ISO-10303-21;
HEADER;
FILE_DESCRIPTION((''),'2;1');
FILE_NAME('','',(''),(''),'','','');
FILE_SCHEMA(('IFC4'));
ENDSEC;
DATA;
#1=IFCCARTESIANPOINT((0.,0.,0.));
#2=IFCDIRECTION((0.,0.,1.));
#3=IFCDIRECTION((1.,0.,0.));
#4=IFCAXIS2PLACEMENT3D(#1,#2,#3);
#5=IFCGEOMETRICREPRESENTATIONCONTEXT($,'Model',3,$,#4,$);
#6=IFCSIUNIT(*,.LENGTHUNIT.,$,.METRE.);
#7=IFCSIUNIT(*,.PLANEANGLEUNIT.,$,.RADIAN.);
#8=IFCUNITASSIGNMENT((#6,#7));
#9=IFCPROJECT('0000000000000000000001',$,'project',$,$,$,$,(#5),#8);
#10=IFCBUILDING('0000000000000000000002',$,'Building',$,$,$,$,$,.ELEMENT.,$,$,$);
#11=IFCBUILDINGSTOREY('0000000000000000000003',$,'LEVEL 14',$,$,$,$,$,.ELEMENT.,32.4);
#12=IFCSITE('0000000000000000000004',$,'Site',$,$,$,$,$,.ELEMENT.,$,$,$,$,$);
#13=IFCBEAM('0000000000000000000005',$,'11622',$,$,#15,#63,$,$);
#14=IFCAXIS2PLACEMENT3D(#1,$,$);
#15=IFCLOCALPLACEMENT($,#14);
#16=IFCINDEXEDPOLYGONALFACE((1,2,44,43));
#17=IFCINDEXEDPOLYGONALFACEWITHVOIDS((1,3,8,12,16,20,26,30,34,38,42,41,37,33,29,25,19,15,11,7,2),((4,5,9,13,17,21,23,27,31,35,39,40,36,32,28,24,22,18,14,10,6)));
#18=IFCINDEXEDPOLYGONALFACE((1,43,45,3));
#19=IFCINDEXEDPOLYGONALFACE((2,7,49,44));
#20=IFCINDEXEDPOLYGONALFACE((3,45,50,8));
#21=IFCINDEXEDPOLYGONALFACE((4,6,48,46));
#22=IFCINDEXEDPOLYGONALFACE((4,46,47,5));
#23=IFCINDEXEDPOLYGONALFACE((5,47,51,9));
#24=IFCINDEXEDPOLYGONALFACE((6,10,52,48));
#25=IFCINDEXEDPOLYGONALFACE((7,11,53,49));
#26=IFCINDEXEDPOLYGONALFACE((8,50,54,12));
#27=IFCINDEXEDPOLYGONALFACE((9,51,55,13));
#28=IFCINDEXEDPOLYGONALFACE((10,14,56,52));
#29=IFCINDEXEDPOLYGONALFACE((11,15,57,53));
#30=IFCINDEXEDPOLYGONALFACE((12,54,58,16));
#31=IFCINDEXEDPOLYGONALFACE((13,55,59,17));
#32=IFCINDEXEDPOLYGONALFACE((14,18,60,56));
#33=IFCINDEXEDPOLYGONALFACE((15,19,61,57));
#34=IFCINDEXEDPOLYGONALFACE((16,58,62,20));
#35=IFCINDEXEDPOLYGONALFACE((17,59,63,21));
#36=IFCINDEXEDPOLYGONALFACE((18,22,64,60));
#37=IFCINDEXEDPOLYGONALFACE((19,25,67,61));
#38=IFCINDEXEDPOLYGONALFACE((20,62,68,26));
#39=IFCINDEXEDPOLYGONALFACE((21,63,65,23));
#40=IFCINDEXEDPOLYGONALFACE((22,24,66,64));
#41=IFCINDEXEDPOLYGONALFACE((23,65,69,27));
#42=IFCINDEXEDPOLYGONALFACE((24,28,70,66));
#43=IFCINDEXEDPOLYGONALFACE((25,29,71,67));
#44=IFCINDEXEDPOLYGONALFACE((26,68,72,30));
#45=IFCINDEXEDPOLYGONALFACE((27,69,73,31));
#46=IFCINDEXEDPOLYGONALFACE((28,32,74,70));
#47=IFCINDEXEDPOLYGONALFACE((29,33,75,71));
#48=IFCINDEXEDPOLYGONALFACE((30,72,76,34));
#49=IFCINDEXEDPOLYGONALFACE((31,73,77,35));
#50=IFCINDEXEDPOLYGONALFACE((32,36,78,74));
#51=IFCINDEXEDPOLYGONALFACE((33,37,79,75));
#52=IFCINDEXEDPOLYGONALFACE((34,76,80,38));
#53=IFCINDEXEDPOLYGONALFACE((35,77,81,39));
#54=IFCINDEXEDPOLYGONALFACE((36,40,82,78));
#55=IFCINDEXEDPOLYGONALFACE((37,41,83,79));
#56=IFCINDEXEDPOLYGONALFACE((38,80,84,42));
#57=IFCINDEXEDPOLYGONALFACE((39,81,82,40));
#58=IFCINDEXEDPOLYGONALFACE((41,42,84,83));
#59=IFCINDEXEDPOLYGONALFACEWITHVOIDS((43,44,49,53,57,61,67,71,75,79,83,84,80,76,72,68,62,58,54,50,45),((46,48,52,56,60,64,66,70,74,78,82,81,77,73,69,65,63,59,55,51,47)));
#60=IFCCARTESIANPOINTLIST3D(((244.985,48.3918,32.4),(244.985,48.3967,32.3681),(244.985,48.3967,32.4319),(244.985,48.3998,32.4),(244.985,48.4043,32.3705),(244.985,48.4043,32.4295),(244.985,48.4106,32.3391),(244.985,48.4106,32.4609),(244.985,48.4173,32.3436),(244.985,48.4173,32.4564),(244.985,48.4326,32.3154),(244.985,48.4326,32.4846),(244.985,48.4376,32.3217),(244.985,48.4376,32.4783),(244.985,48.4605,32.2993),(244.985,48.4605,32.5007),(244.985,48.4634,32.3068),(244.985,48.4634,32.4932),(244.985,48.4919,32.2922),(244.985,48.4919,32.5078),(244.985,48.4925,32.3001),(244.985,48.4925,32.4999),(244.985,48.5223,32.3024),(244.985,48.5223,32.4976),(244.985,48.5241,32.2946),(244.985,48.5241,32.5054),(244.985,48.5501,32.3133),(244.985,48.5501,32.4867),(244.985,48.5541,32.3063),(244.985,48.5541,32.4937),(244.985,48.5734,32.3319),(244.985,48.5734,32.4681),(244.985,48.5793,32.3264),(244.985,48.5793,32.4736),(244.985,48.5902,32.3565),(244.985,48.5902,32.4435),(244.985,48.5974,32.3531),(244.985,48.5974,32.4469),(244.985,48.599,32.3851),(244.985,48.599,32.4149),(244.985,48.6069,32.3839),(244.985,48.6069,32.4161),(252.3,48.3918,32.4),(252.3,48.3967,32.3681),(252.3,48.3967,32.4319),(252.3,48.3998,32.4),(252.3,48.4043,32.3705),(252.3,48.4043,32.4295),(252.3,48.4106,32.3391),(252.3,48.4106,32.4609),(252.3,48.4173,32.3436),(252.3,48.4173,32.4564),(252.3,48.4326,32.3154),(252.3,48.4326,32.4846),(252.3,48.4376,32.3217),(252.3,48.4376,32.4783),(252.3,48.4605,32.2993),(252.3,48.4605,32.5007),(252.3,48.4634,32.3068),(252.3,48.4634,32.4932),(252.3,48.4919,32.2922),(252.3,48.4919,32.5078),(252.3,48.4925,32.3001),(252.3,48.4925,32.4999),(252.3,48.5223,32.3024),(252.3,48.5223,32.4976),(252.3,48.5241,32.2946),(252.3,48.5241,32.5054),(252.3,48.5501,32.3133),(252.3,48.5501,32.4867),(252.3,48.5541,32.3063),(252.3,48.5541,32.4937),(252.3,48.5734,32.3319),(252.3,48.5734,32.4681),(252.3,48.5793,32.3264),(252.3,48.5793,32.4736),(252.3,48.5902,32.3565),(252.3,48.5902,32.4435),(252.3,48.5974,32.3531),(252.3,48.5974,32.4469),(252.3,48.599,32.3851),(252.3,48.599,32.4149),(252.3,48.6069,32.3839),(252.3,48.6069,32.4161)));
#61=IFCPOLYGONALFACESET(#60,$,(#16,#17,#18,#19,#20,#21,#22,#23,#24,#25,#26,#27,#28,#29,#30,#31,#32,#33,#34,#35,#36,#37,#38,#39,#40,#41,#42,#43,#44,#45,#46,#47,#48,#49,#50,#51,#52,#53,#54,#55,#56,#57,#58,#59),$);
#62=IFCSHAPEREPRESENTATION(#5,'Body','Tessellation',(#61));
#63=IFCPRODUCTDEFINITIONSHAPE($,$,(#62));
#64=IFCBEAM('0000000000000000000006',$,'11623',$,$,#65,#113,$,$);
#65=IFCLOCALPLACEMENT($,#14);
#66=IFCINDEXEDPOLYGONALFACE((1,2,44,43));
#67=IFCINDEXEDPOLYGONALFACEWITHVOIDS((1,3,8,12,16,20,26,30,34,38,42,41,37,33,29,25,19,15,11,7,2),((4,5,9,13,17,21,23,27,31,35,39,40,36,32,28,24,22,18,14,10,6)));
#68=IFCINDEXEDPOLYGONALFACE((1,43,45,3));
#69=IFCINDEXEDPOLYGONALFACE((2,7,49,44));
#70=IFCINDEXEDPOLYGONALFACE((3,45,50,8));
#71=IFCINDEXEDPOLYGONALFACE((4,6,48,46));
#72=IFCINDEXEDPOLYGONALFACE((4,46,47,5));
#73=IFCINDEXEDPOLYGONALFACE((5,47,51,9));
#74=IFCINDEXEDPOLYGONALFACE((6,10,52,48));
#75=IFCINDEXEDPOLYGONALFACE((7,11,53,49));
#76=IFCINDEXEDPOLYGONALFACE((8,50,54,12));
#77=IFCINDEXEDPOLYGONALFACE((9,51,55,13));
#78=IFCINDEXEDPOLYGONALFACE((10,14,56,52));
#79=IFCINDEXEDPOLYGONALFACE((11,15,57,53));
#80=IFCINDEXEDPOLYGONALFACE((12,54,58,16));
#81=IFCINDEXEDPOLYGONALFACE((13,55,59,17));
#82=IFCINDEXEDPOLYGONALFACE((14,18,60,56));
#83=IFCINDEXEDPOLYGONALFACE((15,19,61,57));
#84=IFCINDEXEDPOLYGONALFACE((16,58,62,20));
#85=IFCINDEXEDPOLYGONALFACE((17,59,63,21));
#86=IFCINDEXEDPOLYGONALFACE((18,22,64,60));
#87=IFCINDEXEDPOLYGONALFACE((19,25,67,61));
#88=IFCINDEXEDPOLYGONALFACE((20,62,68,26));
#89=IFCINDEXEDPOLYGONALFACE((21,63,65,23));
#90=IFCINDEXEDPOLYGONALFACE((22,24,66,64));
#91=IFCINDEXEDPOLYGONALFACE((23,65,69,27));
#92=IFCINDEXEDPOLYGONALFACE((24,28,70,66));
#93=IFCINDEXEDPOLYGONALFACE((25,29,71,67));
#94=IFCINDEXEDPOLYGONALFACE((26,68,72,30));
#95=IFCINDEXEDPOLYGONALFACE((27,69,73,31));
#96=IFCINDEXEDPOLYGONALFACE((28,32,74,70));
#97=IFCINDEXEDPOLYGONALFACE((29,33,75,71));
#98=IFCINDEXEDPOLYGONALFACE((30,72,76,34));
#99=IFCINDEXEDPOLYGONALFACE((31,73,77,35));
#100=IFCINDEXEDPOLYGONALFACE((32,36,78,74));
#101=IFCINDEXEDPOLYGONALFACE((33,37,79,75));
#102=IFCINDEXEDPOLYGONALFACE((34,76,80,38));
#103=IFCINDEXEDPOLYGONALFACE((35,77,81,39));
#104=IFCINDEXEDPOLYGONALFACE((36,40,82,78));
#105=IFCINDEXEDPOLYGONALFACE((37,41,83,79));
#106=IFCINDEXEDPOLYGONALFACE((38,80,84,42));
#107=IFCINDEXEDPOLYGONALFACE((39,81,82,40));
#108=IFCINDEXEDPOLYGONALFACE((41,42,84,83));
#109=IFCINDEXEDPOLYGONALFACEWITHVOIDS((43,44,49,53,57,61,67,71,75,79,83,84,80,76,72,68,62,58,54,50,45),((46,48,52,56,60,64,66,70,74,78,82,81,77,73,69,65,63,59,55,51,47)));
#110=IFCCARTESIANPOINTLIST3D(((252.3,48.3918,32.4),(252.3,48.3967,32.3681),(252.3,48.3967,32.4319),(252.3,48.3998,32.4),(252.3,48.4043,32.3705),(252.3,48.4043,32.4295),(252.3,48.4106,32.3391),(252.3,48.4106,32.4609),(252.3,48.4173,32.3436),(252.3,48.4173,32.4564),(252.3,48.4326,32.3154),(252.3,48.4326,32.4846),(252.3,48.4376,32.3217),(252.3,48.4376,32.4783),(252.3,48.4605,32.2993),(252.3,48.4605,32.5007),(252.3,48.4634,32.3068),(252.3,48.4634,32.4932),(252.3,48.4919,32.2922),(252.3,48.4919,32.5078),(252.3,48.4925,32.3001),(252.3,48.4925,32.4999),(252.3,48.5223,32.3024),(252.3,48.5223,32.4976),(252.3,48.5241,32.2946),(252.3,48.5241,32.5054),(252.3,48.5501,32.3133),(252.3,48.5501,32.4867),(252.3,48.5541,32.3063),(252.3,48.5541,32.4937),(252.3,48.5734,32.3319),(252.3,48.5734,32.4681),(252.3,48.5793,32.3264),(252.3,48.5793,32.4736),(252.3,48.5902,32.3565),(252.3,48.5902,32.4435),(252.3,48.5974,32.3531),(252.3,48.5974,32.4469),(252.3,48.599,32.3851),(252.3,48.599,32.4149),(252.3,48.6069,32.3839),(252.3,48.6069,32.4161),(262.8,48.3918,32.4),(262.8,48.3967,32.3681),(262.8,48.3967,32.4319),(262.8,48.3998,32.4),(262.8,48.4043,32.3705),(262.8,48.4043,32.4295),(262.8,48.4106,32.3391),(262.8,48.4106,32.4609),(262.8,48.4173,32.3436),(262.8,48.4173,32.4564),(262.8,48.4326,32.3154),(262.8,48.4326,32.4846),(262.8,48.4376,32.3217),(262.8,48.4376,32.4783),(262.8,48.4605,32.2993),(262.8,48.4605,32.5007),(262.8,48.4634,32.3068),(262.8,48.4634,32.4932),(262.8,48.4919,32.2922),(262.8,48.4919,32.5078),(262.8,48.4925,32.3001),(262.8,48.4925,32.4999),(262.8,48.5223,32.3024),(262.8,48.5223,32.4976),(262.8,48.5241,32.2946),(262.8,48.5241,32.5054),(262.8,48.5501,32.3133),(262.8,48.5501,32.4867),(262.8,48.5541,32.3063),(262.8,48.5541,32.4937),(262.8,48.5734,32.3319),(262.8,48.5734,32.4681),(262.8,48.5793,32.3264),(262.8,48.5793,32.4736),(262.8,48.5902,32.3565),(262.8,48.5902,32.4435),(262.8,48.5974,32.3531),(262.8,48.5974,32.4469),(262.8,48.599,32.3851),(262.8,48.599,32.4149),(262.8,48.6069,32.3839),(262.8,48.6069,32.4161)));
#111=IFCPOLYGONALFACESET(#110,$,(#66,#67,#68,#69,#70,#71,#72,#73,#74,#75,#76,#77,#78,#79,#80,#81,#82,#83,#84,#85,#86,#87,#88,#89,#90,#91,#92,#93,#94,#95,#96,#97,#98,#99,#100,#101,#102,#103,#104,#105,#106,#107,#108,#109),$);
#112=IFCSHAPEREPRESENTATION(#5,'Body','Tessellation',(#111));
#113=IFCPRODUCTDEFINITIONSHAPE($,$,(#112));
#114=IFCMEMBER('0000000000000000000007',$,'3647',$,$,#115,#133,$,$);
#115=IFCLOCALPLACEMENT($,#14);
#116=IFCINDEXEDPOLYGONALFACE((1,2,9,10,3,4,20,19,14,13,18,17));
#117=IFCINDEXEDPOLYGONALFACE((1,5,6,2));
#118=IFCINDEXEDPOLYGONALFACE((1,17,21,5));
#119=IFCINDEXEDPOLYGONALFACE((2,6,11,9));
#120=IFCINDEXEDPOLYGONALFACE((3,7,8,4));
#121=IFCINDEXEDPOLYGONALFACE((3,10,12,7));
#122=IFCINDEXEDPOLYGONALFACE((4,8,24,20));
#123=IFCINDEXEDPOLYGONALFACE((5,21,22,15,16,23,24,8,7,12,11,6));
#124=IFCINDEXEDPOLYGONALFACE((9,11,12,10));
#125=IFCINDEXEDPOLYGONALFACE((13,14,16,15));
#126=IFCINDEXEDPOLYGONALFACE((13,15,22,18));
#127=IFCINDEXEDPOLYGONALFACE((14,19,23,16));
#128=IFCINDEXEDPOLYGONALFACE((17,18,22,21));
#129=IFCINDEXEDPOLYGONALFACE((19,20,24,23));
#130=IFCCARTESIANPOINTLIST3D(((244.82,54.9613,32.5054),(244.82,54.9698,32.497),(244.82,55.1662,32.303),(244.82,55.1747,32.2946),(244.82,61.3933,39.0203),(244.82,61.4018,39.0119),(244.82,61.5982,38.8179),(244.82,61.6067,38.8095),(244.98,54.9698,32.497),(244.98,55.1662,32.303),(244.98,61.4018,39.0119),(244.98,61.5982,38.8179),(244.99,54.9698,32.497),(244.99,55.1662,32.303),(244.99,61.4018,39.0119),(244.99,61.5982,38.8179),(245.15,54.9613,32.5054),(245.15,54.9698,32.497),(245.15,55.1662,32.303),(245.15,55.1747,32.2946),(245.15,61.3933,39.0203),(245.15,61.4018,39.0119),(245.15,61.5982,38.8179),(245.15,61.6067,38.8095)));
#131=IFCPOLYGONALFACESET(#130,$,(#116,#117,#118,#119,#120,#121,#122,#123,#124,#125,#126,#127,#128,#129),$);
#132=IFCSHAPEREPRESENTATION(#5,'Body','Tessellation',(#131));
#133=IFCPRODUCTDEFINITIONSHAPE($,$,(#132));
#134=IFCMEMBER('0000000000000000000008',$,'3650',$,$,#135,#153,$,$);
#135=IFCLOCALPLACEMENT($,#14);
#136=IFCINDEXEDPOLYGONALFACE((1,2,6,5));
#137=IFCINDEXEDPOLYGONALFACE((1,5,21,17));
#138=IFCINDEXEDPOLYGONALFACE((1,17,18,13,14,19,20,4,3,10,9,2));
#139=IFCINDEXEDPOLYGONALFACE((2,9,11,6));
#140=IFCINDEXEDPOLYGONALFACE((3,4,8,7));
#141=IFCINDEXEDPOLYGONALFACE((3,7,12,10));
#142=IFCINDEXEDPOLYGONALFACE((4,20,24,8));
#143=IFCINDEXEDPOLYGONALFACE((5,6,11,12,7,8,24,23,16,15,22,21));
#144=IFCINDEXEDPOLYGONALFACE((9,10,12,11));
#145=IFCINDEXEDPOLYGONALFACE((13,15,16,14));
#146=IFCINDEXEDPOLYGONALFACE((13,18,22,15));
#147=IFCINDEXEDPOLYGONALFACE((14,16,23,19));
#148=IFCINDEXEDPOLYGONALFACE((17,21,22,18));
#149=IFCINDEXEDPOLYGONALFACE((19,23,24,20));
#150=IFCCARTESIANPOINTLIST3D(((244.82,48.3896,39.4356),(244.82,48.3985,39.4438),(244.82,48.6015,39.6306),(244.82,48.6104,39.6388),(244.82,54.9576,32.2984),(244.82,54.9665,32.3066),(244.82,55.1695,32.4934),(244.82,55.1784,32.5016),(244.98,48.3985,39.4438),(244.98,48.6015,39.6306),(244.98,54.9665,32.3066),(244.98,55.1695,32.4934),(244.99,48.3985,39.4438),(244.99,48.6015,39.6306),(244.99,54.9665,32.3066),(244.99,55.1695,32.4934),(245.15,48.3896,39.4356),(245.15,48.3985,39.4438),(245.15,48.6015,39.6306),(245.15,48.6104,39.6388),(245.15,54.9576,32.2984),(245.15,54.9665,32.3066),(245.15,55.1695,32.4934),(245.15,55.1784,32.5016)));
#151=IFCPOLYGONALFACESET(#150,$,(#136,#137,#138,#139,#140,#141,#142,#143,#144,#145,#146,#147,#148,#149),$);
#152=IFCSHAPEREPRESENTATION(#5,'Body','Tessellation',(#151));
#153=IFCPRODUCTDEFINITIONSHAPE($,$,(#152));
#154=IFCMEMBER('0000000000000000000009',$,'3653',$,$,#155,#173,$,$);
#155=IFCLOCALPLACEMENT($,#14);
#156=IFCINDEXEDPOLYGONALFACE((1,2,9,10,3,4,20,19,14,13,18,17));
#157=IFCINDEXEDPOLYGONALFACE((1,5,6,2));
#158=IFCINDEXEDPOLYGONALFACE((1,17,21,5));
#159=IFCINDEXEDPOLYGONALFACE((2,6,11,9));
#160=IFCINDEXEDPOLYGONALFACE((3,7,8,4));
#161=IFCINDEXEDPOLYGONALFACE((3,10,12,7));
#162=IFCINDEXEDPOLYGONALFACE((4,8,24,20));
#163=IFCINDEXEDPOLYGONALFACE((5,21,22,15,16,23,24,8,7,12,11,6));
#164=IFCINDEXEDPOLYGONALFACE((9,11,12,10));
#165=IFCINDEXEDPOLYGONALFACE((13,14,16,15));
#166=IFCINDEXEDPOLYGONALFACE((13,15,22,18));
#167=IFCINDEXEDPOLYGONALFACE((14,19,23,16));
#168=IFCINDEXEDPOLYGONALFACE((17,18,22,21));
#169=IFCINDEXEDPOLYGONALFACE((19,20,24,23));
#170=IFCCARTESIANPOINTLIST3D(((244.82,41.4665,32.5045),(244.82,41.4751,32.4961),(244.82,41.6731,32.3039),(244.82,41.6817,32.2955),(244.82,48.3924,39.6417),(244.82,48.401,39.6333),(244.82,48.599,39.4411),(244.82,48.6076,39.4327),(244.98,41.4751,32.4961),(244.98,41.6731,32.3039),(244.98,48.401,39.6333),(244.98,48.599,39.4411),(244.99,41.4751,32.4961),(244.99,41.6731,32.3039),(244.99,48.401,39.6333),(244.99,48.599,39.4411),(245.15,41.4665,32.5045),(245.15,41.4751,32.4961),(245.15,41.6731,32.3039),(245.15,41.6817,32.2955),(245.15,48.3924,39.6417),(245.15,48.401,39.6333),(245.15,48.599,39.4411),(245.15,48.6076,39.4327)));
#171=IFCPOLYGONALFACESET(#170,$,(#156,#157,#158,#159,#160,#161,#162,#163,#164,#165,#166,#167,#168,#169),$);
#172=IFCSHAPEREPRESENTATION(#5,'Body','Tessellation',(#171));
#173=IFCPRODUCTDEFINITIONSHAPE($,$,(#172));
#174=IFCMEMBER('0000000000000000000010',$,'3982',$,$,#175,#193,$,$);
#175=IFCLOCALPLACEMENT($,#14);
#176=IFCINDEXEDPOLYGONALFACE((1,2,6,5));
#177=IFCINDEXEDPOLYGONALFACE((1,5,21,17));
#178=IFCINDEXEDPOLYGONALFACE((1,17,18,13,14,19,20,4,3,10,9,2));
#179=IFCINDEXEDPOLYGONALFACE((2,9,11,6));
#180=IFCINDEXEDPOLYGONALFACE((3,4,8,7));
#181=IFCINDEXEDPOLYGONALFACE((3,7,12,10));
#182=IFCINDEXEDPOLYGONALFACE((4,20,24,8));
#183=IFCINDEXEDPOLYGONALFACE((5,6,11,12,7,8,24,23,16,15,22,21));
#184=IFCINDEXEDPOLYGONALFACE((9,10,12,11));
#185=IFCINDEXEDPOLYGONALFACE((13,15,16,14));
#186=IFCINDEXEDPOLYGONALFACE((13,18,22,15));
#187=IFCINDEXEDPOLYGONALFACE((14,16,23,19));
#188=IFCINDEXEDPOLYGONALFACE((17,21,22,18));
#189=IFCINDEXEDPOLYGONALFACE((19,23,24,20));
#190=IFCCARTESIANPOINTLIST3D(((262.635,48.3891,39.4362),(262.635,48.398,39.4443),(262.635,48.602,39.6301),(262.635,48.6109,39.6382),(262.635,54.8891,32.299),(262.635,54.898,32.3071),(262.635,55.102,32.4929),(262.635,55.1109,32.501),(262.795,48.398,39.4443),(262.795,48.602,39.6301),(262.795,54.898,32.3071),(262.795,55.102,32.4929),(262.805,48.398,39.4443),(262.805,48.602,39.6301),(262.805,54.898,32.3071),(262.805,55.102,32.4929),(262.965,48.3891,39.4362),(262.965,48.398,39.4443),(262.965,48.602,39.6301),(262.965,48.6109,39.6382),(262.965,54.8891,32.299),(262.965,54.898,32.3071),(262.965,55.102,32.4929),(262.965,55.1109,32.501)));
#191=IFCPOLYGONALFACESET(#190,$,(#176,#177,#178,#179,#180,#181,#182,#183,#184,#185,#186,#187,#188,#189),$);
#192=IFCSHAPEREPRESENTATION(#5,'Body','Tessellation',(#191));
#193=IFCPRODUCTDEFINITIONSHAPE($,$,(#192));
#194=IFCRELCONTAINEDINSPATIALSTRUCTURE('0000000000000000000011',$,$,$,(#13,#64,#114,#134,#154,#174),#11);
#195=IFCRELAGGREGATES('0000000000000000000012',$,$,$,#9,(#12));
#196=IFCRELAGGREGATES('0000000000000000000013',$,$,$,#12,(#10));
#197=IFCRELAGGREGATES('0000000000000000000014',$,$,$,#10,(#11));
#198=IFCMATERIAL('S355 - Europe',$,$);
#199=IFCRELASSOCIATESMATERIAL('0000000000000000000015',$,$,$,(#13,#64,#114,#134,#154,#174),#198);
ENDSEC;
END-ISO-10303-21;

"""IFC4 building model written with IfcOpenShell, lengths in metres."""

from ifc_helpers import new_model, si_unit, frame, origin_with_axes, origin_2d_with_axis, place, context, project, spatial, hollow_circle, i_section, extrude, material, material_profile, profile_set, profile_usage, element, save


model = new_model("IFC4")

# Units and contexts
model_context = context("Model", 3, world=origin_with_axes())
ifc_project = project(units=[si_unit("LENGTHUNIT", "METRE"), si_unit("PLANEANGLEUNIT", "RADIAN")], contexts=[model_context])

# Site, building, storey
site = spatial("IfcSite", under=ifc_project, Name="Site", CompositionType="ELEMENT")
building = spatial("IfcBuilding", under=site, Name="Building", CompositionType="ELEMENT")
storey = spatial("IfcBuildingStorey", under=building, Name="LEVEL 14", CompositionType="ELEMENT", Elevation=32.4)

# Shared definitions
ifc_material = material(Name="S355 - Europe")

# Beams
ifc_material_profile_1 = material_profile(ifc_material, hollow_circle(Radius=0.1081, WallThickness=0.008, at=origin_2d_with_axis()))
ifc_profile_set_1 = profile_set([ifc_material_profile_1])
ifc_profile_usage_1 = profile_usage(ifc_profile_set_1, cardinal=10)
beam_1_placement = place(None, frame((252.3, 48.5, 32.4), z_axis=(-1.0, 0.0, 0.0), x_axis=(0.0, -1.0, 0.0)))
element("IfcBeam", 1, at=beam_1_placement, inside=storey, material=ifc_profile_usage_1, Name="11622", context=model_context, shape_type="SweptSolid", body=[
    extrude(hollow_circle(Radius=0.1081, WallThickness=0.008, at=origin_2d_with_axis()), origin_with_axes(), (0.0, 0.0, 1.0), 7.315),
])
ifc_material_profile_2 = material_profile(ifc_material, hollow_circle(Radius=0.1081, WallThickness=0.008, at=origin_2d_with_axis()))
ifc_profile_set_2 = profile_set([ifc_material_profile_2])
ifc_profile_usage_2 = profile_usage(ifc_profile_set_2, cardinal=10)
beam_2_placement = place(None, frame((262.8, 48.5, 32.4), z_axis=(-1.0, 0.0, 0.0), x_axis=(0.0, -1.0, 0.0)))
element("IfcBeam", 2, at=beam_2_placement, inside=storey, material=ifc_profile_usage_2, Name="11623", context=model_context, shape_type="SweptSolid", body=[
    extrude(hollow_circle(Radius=0.1081, WallThickness=0.008, at=origin_2d_with_axis()), origin_with_axes(), (0.0, 0.0, 1.0), 10.5),
])

# Members
ifc_material_profile_3 = material_profile(ifc_material, i_section(OverallWidth=0.33, OverallDepth=0.3, WebThickness=0.01, FlangeThickness=0.012, at=origin_2d_with_axis()))
ifc_profile_set_3 = profile_set([ifc_material_profile_3])
ifc_profile_usage_3 = profile_usage(ifc_profile_set_3, cardinal=10)
member_1_placement = place(None, frame((244.985, 61.5, 38.9149), z_axis=(0.0, -0.702565, -0.71162), x_axis=(1.0, 0.0, 0.0)))
element("IfcMember", 3, at=member_1_placement, inside=storey, material=ifc_profile_usage_3, Name="3647", context=model_context, shape_type="SweptSolid", body=[
    extrude(i_section(OverallWidth=0.33, OverallDepth=0.3, WebThickness=0.01, FlangeThickness=0.012, at=origin_2d_with_axis()), origin_with_axes(), (0.0, 0.0, 1.0), 9.155),
])
ifc_material_profile_4 = material_profile(ifc_material, i_section(OverallWidth=0.33, OverallDepth=0.3, WebThickness=0.01, FlangeThickness=0.012, at=origin_2d_with_axis()))
ifc_profile_set_4 = profile_set([ifc_material_profile_4])
ifc_profile_usage_4 = profile_usage(ifc_profile_set_4, cardinal=10)
member_2_placement = place(None, frame((244.985, 55.068, 32.4), z_axis=(0.0, -0.677156, 0.73584), x_axis=(1.0, 0.0, 0.0)))
element("IfcMember", 4, at=member_2_placement, inside=storey, material=ifc_profile_usage_4, Name="3650", context=model_context, shape_type="SweptSolid", body=[
    extrude(i_section(OverallWidth=0.33, OverallDepth=0.3, WebThickness=0.01, FlangeThickness=0.012, at=origin_2d_with_axis()), origin_with_axes(), (0.0, 0.0, 1.0), 9.6994),
])
ifc_material_profile_5 = material_profile(ifc_material, i_section(OverallWidth=0.33, OverallDepth=0.3, WebThickness=0.01, FlangeThickness=0.012, at=origin_2d_with_axis()))
ifc_profile_set_5 = profile_set([ifc_material_profile_5])
ifc_profile_usage_5 = profile_usage(ifc_profile_set_5, cardinal=10)
member_3_placement = place(None, frame((244.985, 48.5, 39.5372), z_axis=(0.0, -0.696404, -0.71765), x_axis=(1.0, 0.0, 0.0)))
element("IfcMember", 5, at=member_3_placement, inside=storey, material=ifc_profile_usage_5, Name="3653", context=model_context, shape_type="SweptSolid", body=[
    extrude(i_section(OverallWidth=0.33, OverallDepth=0.3, WebThickness=0.01, FlangeThickness=0.012, at=origin_2d_with_axis()), origin_with_axes(), (0.0, 0.0, 1.0), 9.9452),
])
ifc_material_profile_6 = material_profile(ifc_material, i_section(OverallWidth=0.33, OverallDepth=0.3, WebThickness=0.01, FlangeThickness=0.012, at=origin_2d_with_axis()))
ifc_profile_set_6 = profile_set([ifc_material_profile_6])
ifc_profile_usage_6 = profile_usage(ifc_profile_set_6, cardinal=10)
member_4_placement = place(None, frame((262.8, 55.0, 32.4), z_axis=(0.0, -0.673333, 0.73934), x_axis=(1.0, 0.0, 0.0)))
element("IfcMember", 6, at=member_4_placement, inside=storey, material=ifc_profile_usage_6, Name="3982", context=model_context, shape_type="SweptSolid", body=[
    extrude(i_section(OverallWidth=0.33, OverallDepth=0.3, WebThickness=0.01, FlangeThickness=0.012, at=origin_2d_with_axis()), origin_with_axes(), (0.0, 0.0, 1.0), 9.6535),
])

save(model, "model.ifc")
